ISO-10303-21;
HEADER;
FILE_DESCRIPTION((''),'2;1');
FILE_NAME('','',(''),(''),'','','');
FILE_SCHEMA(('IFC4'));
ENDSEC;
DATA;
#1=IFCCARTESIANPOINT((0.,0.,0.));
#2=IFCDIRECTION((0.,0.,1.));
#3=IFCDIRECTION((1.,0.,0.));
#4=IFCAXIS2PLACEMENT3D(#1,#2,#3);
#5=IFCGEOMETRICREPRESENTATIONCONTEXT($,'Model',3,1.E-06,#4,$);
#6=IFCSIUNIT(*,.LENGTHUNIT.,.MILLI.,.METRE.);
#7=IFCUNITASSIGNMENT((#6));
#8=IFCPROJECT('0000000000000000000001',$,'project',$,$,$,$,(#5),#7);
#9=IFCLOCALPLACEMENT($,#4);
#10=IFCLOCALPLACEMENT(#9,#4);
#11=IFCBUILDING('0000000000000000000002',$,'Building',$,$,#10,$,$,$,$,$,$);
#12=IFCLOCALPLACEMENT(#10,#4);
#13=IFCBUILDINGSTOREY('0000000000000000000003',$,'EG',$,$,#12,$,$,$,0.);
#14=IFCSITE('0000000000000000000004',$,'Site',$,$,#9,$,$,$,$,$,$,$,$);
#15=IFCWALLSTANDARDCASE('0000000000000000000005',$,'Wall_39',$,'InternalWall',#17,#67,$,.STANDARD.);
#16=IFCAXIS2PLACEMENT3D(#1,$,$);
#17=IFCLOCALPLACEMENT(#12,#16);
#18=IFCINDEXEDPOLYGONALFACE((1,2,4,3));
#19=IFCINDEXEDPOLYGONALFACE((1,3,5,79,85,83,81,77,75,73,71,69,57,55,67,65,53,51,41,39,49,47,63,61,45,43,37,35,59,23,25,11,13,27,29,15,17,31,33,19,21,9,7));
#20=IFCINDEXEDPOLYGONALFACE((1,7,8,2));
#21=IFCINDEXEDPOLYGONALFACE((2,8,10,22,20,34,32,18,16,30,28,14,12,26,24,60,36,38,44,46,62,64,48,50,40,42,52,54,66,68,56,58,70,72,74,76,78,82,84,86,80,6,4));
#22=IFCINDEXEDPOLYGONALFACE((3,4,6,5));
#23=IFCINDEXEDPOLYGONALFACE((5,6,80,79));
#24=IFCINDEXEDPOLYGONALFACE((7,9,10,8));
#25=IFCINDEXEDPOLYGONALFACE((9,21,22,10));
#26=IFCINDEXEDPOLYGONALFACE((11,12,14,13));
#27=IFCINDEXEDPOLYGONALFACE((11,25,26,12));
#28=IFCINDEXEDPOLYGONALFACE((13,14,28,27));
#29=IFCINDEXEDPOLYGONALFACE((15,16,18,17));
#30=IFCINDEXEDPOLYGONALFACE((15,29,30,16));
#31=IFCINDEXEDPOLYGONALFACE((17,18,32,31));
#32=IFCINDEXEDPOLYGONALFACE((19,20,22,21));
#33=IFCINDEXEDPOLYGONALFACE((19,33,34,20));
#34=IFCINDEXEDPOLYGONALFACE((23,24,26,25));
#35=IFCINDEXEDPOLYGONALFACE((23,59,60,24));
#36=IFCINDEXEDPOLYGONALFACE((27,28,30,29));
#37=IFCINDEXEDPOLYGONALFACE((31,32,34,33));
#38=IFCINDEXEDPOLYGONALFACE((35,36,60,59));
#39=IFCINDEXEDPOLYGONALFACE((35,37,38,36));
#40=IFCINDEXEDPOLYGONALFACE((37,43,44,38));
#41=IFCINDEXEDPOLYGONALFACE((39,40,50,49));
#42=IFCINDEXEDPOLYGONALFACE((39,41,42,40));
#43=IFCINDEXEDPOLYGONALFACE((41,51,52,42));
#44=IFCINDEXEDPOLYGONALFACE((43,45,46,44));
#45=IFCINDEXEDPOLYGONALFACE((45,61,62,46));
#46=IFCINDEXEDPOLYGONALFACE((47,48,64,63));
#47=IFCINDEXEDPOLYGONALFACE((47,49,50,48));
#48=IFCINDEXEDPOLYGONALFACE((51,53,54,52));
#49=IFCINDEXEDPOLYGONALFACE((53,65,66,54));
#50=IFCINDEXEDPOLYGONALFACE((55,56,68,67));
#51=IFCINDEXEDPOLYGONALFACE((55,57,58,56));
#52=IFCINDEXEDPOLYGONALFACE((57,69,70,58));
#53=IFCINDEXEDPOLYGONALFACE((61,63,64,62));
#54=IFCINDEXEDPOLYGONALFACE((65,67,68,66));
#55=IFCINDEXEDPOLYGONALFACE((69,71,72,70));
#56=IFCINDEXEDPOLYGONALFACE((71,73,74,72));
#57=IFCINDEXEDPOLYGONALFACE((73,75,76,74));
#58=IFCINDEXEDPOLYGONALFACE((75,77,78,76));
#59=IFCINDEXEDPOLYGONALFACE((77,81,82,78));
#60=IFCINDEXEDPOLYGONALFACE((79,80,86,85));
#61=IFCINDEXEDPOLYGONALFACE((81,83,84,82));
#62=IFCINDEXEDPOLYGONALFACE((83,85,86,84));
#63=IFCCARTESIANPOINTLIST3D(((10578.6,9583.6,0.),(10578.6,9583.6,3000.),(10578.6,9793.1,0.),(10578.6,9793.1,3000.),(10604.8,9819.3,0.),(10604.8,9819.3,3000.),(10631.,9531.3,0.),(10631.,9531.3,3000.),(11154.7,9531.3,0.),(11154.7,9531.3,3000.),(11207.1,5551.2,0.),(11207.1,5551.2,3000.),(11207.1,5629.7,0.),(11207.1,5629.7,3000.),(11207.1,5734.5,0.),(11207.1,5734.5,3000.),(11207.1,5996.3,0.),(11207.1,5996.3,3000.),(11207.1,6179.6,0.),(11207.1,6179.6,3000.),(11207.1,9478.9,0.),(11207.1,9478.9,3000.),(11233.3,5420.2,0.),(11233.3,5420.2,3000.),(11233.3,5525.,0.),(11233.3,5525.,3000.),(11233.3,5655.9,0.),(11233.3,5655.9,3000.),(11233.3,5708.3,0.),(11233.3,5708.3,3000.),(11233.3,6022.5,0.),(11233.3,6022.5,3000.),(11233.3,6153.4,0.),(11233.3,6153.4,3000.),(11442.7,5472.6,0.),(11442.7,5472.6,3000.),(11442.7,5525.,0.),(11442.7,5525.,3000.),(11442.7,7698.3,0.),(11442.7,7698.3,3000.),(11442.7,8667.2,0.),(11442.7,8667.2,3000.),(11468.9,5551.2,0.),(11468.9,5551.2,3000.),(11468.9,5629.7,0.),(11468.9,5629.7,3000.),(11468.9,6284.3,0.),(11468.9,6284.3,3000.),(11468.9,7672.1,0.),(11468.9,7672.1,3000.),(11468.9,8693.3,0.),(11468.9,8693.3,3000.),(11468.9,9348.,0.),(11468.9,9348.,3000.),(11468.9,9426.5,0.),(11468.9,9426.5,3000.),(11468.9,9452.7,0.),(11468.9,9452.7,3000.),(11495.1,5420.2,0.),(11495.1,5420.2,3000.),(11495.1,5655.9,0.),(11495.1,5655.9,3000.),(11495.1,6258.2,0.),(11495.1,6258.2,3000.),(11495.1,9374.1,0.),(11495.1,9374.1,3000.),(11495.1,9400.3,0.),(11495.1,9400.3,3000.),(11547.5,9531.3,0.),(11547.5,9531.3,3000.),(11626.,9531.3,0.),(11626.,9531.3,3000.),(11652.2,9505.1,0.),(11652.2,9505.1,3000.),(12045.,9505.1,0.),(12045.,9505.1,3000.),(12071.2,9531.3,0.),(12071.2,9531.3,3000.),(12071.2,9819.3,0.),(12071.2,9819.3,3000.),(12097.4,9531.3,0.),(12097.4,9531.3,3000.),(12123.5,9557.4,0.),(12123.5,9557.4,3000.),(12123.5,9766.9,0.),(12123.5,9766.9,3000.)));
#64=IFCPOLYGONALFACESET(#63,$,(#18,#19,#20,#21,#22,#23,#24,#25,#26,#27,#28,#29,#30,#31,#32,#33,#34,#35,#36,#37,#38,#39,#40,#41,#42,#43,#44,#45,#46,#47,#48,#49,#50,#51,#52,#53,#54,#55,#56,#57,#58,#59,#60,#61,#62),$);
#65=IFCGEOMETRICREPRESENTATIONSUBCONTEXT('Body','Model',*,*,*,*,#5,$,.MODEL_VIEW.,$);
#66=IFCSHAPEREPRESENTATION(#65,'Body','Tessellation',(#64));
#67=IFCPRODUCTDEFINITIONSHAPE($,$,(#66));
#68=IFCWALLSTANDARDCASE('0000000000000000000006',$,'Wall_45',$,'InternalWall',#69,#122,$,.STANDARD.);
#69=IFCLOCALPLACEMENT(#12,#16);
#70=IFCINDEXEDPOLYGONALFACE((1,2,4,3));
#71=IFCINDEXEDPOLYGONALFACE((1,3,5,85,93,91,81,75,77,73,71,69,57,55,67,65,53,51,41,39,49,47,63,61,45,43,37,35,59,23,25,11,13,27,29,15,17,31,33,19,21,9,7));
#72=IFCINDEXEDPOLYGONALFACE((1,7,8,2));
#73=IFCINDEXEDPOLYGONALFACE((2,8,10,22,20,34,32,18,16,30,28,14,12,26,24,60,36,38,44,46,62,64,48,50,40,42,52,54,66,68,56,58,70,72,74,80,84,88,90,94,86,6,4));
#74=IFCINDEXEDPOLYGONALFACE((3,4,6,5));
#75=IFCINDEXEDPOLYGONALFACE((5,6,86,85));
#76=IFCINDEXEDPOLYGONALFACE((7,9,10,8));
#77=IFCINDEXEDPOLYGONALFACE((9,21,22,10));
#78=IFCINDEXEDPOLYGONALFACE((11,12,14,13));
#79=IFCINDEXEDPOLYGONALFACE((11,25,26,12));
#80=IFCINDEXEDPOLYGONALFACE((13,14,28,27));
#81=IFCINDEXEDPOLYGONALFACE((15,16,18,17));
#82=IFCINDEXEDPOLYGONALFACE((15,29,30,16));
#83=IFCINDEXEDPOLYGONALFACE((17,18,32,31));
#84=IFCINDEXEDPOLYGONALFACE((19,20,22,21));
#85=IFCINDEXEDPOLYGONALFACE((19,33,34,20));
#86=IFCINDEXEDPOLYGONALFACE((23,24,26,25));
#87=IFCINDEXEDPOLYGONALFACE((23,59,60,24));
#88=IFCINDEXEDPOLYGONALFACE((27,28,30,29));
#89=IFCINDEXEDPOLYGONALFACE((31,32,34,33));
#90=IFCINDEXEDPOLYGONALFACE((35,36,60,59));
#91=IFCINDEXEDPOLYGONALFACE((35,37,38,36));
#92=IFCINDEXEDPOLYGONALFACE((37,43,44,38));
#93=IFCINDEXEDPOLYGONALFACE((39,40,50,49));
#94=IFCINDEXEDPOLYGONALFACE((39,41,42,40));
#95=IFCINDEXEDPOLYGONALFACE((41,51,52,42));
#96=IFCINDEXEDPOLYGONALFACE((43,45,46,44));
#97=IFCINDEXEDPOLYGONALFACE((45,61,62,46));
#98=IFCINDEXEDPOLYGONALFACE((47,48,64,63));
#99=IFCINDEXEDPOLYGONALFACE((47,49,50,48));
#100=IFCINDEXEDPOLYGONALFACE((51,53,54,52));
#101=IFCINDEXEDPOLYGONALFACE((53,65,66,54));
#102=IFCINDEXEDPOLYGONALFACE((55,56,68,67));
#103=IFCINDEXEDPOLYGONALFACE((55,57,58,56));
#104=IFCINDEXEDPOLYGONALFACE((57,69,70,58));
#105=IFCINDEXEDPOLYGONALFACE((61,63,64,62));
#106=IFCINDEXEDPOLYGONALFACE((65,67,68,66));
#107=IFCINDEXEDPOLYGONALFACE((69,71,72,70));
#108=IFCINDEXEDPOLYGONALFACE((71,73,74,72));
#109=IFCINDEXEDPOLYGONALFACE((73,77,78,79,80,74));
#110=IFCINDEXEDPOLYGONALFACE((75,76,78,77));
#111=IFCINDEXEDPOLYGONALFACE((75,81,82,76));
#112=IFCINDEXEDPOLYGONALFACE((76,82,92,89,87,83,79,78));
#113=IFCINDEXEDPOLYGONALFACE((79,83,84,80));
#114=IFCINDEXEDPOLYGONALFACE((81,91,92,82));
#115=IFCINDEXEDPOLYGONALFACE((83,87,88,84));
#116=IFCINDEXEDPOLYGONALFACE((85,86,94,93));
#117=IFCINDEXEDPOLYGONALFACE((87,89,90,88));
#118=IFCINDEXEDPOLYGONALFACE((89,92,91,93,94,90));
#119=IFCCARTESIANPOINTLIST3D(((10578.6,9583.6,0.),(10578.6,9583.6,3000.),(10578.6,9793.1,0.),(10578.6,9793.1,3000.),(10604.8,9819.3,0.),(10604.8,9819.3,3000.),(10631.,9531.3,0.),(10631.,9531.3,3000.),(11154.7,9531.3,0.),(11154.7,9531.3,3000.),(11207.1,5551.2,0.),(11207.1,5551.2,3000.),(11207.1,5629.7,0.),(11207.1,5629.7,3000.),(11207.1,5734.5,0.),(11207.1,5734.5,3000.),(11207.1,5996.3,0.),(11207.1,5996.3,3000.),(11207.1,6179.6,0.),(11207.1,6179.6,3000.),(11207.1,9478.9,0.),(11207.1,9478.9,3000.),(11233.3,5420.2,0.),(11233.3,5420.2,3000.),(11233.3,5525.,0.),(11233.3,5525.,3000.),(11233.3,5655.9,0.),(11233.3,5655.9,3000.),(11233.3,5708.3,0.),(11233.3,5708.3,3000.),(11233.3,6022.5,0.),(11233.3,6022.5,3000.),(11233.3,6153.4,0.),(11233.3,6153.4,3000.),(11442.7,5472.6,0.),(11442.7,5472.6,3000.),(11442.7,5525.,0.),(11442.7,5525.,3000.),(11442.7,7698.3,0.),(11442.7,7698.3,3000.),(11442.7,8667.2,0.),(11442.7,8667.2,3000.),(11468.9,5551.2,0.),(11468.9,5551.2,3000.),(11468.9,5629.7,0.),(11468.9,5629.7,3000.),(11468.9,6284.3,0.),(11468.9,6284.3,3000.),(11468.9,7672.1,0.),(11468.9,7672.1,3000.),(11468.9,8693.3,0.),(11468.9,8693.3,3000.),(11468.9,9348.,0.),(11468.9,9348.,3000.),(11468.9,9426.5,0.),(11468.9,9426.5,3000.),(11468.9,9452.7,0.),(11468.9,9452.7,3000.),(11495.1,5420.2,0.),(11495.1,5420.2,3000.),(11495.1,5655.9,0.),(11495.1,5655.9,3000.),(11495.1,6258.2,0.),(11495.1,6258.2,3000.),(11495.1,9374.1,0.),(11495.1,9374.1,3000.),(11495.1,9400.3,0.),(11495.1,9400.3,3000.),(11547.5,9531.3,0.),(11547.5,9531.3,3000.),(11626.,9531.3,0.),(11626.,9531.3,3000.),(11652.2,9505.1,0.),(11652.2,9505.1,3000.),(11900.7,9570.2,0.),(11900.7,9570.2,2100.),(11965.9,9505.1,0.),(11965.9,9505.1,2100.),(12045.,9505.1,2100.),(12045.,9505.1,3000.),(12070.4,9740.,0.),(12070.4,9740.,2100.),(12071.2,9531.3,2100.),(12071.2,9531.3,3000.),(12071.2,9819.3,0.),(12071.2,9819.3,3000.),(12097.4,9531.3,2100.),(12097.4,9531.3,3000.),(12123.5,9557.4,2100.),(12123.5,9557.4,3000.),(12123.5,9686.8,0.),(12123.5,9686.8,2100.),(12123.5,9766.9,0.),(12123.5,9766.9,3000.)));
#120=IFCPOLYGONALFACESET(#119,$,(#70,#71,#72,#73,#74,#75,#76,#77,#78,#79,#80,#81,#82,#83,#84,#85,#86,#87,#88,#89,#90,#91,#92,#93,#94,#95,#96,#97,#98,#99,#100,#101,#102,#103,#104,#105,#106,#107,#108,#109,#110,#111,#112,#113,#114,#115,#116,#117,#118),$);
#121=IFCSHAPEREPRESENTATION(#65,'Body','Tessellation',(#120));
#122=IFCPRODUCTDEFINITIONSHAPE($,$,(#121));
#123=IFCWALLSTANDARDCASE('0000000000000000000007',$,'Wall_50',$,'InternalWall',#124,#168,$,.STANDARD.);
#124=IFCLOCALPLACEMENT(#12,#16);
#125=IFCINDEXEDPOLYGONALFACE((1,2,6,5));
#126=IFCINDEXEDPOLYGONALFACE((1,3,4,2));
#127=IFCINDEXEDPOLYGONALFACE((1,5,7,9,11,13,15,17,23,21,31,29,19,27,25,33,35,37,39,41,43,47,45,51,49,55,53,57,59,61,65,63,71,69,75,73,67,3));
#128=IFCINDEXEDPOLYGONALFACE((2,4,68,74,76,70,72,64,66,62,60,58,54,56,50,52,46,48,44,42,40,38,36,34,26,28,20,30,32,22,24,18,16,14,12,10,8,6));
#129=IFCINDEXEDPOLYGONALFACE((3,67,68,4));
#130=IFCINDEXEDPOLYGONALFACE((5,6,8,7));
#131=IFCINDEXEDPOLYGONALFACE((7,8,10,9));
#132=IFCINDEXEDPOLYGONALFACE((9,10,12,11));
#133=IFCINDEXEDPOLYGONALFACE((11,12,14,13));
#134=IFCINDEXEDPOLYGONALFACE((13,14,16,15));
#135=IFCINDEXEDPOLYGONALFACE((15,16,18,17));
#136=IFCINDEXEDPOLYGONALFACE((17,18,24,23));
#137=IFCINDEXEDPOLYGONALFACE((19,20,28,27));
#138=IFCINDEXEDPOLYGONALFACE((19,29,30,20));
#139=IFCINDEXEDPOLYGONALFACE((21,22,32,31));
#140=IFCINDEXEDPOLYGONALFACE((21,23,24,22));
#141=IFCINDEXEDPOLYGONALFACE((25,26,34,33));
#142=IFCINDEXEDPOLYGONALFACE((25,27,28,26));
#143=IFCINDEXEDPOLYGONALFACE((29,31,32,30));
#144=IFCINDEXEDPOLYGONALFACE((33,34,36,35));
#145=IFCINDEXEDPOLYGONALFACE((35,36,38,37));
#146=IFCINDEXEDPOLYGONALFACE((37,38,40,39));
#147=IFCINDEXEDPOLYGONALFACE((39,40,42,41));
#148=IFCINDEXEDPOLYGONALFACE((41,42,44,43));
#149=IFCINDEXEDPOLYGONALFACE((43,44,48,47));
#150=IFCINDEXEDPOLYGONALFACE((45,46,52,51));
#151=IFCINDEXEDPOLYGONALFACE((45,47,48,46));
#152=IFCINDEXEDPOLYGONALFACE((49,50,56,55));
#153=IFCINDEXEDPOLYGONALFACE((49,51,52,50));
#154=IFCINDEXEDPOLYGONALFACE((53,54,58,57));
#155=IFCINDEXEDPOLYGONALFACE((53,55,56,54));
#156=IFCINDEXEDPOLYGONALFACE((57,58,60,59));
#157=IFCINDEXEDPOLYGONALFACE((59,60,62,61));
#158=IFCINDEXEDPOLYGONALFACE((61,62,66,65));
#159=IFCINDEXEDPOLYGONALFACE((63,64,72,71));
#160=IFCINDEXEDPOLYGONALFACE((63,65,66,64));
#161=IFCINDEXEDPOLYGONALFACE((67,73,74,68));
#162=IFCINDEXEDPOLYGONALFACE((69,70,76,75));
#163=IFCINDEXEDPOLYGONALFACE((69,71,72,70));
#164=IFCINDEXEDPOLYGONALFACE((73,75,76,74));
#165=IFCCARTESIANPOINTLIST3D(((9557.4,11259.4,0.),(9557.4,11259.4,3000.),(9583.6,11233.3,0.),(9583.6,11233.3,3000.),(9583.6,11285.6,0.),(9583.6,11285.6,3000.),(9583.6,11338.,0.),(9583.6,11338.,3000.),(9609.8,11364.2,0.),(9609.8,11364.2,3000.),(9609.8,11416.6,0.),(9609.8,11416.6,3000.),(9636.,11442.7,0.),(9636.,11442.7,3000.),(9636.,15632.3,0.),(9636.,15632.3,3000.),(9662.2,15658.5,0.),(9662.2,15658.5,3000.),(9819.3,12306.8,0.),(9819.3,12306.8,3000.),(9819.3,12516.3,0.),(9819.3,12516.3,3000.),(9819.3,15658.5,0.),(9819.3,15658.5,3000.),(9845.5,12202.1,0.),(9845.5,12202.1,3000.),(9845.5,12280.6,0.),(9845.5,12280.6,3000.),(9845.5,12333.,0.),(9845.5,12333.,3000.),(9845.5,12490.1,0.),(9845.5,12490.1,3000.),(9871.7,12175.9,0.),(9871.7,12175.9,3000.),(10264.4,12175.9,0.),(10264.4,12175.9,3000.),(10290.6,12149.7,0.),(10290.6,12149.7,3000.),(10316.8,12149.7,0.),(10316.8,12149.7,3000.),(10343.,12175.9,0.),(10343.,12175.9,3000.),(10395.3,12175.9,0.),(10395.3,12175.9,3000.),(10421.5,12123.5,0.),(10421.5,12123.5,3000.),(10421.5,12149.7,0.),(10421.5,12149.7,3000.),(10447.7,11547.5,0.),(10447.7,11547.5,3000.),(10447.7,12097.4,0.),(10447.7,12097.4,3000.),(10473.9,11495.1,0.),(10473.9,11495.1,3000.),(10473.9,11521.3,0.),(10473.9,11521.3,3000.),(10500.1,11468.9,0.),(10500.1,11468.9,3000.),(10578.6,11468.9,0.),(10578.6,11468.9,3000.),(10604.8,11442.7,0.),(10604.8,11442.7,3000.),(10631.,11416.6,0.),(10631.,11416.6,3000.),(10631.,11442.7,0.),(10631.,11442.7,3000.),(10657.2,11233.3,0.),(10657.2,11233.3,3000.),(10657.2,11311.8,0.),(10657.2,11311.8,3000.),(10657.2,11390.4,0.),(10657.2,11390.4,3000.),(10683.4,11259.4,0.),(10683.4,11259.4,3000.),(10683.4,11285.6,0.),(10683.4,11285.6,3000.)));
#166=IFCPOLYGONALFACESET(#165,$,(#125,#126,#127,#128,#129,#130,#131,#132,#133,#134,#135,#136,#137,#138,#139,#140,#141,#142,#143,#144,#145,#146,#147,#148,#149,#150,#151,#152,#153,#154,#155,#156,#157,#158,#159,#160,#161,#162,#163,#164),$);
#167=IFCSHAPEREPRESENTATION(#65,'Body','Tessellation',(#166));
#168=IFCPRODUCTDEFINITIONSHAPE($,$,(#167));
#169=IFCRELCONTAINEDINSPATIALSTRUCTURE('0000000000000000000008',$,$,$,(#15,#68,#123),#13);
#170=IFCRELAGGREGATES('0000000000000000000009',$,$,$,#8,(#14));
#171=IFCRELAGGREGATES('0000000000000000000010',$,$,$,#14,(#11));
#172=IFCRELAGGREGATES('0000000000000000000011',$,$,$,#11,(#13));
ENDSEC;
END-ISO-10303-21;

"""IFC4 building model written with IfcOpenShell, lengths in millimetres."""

from ifc_helpers import new_model, si_unit, frame, origin_with_axes, place, context, subcontext, project, spatial, polyline, rectangle, outline, extrude, element, save


model = new_model("IFC4")

# Units and contexts
model_context = context("Model", 3, precision=1e-06, world=origin_with_axes())
body_context = subcontext(model_context, "Body", "Model", "MODEL_VIEW")
ifc_project = project(units=[si_unit("LENGTHUNIT", "METRE", prefix="MILLI")], contexts=[model_context])

# Site, building, storey
site_placement = place(None, origin_with_axes())
site = spatial("IfcSite", under=ifc_project, at=site_placement, Name="Site")
building_placement = place(site_placement, origin_with_axes())
building = spatial("IfcBuilding", under=site, at=building_placement, Name="Building")
storey_placement = place(building_placement, origin_with_axes())
storey = spatial("IfcBuildingStorey", under=building, at=storey_placement, Name="EG", Elevation=0.0)

# Wall
wall_1_placement = place(storey_placement, origin_with_axes())
element("IfcWallStandardCase", 1, at=wall_1_placement, inside=storey, Name="Wall_39", ObjectType="InternalWall", PredefinedType="STANDARD", context=body_context, shape_type="SweptSolid", body=[
    extrude(outline(polyline([(11233.3, 5420.2, 0.0), (11233.3, 5525.0, 0.0), (11207.1, 5551.2, 0.0), (11207.1, 5629.7, 0.0), (11233.3, 5655.9, 0.0), (11233.3, 5708.3, 0.0), (11207.1, 5734.5, 0.0), (11207.1, 5996.3, 0.0), (11233.3, 6022.5, 0.0), (11233.3, 6153.4, 0.0), (11207.1, 6179.6, 0.0), (11207.1, 9478.9, 0.0), (11154.7, 9531.3, 0.0), (10631.0, 9531.3, 0.0), (10578.6, 9583.6, 0.0), (10578.6, 9793.1, 0.0), (10604.8, 9819.3, 0.0), (12071.2, 9819.3, 0.0), (12123.5, 9766.9, 0.0), (12123.5, 9557.4, 0.0), (12097.4, 9531.3, 0.0), (12071.2, 9531.3, 0.0), (12045.0, 9505.1, 0.0), (11652.2, 9505.1, 0.0), (11626.0, 9531.3, 0.0), (11547.5, 9531.3, 0.0), (11468.9, 9452.7, 0.0), (11468.9, 9426.5, 0.0), (11495.1, 9400.3, 0.0), (11495.1, 9374.1, 0.0), (11468.9, 9348.0, 0.0), (11468.9, 8693.3, 0.0), (11442.7, 8667.2, 0.0), (11442.7, 7698.3, 0.0), (11468.9, 7672.1, 0.0), (11468.9, 6284.3, 0.0), (11495.1, 6258.2, 0.0), (11495.1, 5655.9, 0.0), (11468.9, 5629.7, 0.0), (11468.9, 5551.2, 0.0), (11442.7, 5525.0, 0.0), (11442.7, 5472.6, 0.0), (11495.1, 5420.2, 0.0), (11233.3, 5420.2, 0.0)])), origin_with_axes(), (0.0, 0.0, 1.0), 3000.0),
])

# Wall, opening
wall_2_placement = place(storey_placement, origin_with_axes())
wall_2 = element("IfcWallStandardCase", 2, at=wall_2_placement, inside=storey, Name="Wall_45", ObjectType="InternalWall", PredefinedType="STANDARD", context=body_context, shape_type="SweptSolid", body=[
    extrude(outline(polyline([(11233.3, 5420.2, 0.0), (11233.3, 5525.0, 0.0), (11207.1, 5551.2, 0.0), (11207.1, 5629.7, 0.0), (11233.3, 5655.9, 0.0), (11233.3, 5708.3, 0.0), (11207.1, 5734.5, 0.0), (11207.1, 5996.3, 0.0), (11233.3, 6022.5, 0.0), (11233.3, 6153.4, 0.0), (11207.1, 6179.6, 0.0), (11207.1, 9478.9, 0.0), (11154.7, 9531.3, 0.0), (10631.0, 9531.3, 0.0), (10578.6, 9583.6, 0.0), (10578.6, 9793.1, 0.0), (10604.8, 9819.3, 0.0), (12071.2, 9819.3, 0.0), (12123.5, 9766.9, 0.0), (12123.5, 9557.4, 0.0), (12097.4, 9531.3, 0.0), (12071.2, 9531.3, 0.0), (12045.0, 9505.1, 0.0), (11652.2, 9505.1, 0.0), (11626.0, 9531.3, 0.0), (11547.5, 9531.3, 0.0), (11468.9, 9452.7, 0.0), (11468.9, 9426.5, 0.0), (11495.1, 9400.3, 0.0), (11495.1, 9374.1, 0.0), (11468.9, 9348.0, 0.0), (11468.9, 8693.3, 0.0), (11442.7, 8667.2, 0.0), (11442.7, 7698.3, 0.0), (11468.9, 7672.1, 0.0), (11468.9, 6284.3, 0.0), (11495.1, 6258.2, 0.0), (11495.1, 5655.9, 0.0), (11468.9, 5629.7, 0.0), (11468.9, 5551.2, 0.0), (11442.7, 5525.0, 0.0), (11442.7, 5472.6, 0.0), (11495.1, 5420.2, 0.0), (11233.3, 5420.2, 0.0)])), origin_with_axes(), (0.0, 0.0, 1.0), 3000.0),
])
opening_1_placement = place(wall_2_placement, origin_with_axes())
element("IfcOpeningElement", 3, at=opening_1_placement, inside=storey, cuts=wall_2, context=body_context, shape_type="SweptSolid", body=[
    extrude(rectangle(XDim=1296.1, YDim=240.0), frame((12443.8, 9196.9, 0.0), z_axis=(0.0, 0.0, 1.0), x_axis=(0.707107, -0.707107, 0.0)), (0.0, 0.0, 1.0), 2100.0),
])

# Wall
for number, where, z_axis, x_axis, name in (
    (4, (0.0, 0.0, 0.0), (0.0, 0.0, 1.0), (1.0, 0.0, 0.0), "Wall_50"),
):
    element("IfcWallStandardCase", number, at=place(storey_placement, frame(where, z_axis=z_axis, x_axis=x_axis)), inside=storey, Name=name, ObjectType="InternalWall", PredefinedType="STANDARD", context=body_context, shape_type="SweptSolid", body=[
        extrude(outline(polyline([(9583.6, 11233.3, 0.0), (9557.4, 11259.4, 0.0), (9583.6, 11285.6, 0.0), (9583.6, 11338.0, 0.0), (9609.8, 11364.2, 0.0), (9609.8, 11416.6, 0.0), (9636.0, 11442.7, 0.0), (9636.0, 15632.3, 0.0), (9662.2, 15658.5, 0.0), (9819.3, 15658.5, 0.0), (9819.3, 12516.3, 0.0), (9845.5, 12490.1, 0.0), (9845.5, 12333.0, 0.0), (9819.3, 12306.8, 0.0), (9845.5, 12280.6, 0.0), (9845.5, 12202.1, 0.0), (9871.7, 12175.9, 0.0), (10264.4, 12175.9, 0.0), (10290.6, 12149.7, 0.0), (10316.8, 12149.7, 0.0), (10343.0, 12175.9, 0.0), (10395.3, 12175.9, 0.0), (10421.5, 12149.7, 0.0), (10421.5, 12123.5, 0.0), (10447.7, 12097.4, 0.0), (10447.7, 11547.5, 0.0), (10473.9, 11521.3, 0.0), (10473.9, 11495.1, 0.0), (10500.1, 11468.9, 0.0), (10578.6, 11468.9, 0.0), (10604.8, 11442.7, 0.0), (10631.0, 11442.7, 0.0), (10631.0, 11416.6, 0.0), (10657.2, 11390.4, 0.0), (10657.2, 11311.8, 0.0), (10683.4, 11285.6, 0.0), (10683.4, 11259.4, 0.0), (10657.2, 11233.3, 0.0), (9583.6, 11233.3, 0.0)])), origin_with_axes(), (0.0, 0.0, 1.0), 3000.0),
    ])

save(model, "model.ifc")
